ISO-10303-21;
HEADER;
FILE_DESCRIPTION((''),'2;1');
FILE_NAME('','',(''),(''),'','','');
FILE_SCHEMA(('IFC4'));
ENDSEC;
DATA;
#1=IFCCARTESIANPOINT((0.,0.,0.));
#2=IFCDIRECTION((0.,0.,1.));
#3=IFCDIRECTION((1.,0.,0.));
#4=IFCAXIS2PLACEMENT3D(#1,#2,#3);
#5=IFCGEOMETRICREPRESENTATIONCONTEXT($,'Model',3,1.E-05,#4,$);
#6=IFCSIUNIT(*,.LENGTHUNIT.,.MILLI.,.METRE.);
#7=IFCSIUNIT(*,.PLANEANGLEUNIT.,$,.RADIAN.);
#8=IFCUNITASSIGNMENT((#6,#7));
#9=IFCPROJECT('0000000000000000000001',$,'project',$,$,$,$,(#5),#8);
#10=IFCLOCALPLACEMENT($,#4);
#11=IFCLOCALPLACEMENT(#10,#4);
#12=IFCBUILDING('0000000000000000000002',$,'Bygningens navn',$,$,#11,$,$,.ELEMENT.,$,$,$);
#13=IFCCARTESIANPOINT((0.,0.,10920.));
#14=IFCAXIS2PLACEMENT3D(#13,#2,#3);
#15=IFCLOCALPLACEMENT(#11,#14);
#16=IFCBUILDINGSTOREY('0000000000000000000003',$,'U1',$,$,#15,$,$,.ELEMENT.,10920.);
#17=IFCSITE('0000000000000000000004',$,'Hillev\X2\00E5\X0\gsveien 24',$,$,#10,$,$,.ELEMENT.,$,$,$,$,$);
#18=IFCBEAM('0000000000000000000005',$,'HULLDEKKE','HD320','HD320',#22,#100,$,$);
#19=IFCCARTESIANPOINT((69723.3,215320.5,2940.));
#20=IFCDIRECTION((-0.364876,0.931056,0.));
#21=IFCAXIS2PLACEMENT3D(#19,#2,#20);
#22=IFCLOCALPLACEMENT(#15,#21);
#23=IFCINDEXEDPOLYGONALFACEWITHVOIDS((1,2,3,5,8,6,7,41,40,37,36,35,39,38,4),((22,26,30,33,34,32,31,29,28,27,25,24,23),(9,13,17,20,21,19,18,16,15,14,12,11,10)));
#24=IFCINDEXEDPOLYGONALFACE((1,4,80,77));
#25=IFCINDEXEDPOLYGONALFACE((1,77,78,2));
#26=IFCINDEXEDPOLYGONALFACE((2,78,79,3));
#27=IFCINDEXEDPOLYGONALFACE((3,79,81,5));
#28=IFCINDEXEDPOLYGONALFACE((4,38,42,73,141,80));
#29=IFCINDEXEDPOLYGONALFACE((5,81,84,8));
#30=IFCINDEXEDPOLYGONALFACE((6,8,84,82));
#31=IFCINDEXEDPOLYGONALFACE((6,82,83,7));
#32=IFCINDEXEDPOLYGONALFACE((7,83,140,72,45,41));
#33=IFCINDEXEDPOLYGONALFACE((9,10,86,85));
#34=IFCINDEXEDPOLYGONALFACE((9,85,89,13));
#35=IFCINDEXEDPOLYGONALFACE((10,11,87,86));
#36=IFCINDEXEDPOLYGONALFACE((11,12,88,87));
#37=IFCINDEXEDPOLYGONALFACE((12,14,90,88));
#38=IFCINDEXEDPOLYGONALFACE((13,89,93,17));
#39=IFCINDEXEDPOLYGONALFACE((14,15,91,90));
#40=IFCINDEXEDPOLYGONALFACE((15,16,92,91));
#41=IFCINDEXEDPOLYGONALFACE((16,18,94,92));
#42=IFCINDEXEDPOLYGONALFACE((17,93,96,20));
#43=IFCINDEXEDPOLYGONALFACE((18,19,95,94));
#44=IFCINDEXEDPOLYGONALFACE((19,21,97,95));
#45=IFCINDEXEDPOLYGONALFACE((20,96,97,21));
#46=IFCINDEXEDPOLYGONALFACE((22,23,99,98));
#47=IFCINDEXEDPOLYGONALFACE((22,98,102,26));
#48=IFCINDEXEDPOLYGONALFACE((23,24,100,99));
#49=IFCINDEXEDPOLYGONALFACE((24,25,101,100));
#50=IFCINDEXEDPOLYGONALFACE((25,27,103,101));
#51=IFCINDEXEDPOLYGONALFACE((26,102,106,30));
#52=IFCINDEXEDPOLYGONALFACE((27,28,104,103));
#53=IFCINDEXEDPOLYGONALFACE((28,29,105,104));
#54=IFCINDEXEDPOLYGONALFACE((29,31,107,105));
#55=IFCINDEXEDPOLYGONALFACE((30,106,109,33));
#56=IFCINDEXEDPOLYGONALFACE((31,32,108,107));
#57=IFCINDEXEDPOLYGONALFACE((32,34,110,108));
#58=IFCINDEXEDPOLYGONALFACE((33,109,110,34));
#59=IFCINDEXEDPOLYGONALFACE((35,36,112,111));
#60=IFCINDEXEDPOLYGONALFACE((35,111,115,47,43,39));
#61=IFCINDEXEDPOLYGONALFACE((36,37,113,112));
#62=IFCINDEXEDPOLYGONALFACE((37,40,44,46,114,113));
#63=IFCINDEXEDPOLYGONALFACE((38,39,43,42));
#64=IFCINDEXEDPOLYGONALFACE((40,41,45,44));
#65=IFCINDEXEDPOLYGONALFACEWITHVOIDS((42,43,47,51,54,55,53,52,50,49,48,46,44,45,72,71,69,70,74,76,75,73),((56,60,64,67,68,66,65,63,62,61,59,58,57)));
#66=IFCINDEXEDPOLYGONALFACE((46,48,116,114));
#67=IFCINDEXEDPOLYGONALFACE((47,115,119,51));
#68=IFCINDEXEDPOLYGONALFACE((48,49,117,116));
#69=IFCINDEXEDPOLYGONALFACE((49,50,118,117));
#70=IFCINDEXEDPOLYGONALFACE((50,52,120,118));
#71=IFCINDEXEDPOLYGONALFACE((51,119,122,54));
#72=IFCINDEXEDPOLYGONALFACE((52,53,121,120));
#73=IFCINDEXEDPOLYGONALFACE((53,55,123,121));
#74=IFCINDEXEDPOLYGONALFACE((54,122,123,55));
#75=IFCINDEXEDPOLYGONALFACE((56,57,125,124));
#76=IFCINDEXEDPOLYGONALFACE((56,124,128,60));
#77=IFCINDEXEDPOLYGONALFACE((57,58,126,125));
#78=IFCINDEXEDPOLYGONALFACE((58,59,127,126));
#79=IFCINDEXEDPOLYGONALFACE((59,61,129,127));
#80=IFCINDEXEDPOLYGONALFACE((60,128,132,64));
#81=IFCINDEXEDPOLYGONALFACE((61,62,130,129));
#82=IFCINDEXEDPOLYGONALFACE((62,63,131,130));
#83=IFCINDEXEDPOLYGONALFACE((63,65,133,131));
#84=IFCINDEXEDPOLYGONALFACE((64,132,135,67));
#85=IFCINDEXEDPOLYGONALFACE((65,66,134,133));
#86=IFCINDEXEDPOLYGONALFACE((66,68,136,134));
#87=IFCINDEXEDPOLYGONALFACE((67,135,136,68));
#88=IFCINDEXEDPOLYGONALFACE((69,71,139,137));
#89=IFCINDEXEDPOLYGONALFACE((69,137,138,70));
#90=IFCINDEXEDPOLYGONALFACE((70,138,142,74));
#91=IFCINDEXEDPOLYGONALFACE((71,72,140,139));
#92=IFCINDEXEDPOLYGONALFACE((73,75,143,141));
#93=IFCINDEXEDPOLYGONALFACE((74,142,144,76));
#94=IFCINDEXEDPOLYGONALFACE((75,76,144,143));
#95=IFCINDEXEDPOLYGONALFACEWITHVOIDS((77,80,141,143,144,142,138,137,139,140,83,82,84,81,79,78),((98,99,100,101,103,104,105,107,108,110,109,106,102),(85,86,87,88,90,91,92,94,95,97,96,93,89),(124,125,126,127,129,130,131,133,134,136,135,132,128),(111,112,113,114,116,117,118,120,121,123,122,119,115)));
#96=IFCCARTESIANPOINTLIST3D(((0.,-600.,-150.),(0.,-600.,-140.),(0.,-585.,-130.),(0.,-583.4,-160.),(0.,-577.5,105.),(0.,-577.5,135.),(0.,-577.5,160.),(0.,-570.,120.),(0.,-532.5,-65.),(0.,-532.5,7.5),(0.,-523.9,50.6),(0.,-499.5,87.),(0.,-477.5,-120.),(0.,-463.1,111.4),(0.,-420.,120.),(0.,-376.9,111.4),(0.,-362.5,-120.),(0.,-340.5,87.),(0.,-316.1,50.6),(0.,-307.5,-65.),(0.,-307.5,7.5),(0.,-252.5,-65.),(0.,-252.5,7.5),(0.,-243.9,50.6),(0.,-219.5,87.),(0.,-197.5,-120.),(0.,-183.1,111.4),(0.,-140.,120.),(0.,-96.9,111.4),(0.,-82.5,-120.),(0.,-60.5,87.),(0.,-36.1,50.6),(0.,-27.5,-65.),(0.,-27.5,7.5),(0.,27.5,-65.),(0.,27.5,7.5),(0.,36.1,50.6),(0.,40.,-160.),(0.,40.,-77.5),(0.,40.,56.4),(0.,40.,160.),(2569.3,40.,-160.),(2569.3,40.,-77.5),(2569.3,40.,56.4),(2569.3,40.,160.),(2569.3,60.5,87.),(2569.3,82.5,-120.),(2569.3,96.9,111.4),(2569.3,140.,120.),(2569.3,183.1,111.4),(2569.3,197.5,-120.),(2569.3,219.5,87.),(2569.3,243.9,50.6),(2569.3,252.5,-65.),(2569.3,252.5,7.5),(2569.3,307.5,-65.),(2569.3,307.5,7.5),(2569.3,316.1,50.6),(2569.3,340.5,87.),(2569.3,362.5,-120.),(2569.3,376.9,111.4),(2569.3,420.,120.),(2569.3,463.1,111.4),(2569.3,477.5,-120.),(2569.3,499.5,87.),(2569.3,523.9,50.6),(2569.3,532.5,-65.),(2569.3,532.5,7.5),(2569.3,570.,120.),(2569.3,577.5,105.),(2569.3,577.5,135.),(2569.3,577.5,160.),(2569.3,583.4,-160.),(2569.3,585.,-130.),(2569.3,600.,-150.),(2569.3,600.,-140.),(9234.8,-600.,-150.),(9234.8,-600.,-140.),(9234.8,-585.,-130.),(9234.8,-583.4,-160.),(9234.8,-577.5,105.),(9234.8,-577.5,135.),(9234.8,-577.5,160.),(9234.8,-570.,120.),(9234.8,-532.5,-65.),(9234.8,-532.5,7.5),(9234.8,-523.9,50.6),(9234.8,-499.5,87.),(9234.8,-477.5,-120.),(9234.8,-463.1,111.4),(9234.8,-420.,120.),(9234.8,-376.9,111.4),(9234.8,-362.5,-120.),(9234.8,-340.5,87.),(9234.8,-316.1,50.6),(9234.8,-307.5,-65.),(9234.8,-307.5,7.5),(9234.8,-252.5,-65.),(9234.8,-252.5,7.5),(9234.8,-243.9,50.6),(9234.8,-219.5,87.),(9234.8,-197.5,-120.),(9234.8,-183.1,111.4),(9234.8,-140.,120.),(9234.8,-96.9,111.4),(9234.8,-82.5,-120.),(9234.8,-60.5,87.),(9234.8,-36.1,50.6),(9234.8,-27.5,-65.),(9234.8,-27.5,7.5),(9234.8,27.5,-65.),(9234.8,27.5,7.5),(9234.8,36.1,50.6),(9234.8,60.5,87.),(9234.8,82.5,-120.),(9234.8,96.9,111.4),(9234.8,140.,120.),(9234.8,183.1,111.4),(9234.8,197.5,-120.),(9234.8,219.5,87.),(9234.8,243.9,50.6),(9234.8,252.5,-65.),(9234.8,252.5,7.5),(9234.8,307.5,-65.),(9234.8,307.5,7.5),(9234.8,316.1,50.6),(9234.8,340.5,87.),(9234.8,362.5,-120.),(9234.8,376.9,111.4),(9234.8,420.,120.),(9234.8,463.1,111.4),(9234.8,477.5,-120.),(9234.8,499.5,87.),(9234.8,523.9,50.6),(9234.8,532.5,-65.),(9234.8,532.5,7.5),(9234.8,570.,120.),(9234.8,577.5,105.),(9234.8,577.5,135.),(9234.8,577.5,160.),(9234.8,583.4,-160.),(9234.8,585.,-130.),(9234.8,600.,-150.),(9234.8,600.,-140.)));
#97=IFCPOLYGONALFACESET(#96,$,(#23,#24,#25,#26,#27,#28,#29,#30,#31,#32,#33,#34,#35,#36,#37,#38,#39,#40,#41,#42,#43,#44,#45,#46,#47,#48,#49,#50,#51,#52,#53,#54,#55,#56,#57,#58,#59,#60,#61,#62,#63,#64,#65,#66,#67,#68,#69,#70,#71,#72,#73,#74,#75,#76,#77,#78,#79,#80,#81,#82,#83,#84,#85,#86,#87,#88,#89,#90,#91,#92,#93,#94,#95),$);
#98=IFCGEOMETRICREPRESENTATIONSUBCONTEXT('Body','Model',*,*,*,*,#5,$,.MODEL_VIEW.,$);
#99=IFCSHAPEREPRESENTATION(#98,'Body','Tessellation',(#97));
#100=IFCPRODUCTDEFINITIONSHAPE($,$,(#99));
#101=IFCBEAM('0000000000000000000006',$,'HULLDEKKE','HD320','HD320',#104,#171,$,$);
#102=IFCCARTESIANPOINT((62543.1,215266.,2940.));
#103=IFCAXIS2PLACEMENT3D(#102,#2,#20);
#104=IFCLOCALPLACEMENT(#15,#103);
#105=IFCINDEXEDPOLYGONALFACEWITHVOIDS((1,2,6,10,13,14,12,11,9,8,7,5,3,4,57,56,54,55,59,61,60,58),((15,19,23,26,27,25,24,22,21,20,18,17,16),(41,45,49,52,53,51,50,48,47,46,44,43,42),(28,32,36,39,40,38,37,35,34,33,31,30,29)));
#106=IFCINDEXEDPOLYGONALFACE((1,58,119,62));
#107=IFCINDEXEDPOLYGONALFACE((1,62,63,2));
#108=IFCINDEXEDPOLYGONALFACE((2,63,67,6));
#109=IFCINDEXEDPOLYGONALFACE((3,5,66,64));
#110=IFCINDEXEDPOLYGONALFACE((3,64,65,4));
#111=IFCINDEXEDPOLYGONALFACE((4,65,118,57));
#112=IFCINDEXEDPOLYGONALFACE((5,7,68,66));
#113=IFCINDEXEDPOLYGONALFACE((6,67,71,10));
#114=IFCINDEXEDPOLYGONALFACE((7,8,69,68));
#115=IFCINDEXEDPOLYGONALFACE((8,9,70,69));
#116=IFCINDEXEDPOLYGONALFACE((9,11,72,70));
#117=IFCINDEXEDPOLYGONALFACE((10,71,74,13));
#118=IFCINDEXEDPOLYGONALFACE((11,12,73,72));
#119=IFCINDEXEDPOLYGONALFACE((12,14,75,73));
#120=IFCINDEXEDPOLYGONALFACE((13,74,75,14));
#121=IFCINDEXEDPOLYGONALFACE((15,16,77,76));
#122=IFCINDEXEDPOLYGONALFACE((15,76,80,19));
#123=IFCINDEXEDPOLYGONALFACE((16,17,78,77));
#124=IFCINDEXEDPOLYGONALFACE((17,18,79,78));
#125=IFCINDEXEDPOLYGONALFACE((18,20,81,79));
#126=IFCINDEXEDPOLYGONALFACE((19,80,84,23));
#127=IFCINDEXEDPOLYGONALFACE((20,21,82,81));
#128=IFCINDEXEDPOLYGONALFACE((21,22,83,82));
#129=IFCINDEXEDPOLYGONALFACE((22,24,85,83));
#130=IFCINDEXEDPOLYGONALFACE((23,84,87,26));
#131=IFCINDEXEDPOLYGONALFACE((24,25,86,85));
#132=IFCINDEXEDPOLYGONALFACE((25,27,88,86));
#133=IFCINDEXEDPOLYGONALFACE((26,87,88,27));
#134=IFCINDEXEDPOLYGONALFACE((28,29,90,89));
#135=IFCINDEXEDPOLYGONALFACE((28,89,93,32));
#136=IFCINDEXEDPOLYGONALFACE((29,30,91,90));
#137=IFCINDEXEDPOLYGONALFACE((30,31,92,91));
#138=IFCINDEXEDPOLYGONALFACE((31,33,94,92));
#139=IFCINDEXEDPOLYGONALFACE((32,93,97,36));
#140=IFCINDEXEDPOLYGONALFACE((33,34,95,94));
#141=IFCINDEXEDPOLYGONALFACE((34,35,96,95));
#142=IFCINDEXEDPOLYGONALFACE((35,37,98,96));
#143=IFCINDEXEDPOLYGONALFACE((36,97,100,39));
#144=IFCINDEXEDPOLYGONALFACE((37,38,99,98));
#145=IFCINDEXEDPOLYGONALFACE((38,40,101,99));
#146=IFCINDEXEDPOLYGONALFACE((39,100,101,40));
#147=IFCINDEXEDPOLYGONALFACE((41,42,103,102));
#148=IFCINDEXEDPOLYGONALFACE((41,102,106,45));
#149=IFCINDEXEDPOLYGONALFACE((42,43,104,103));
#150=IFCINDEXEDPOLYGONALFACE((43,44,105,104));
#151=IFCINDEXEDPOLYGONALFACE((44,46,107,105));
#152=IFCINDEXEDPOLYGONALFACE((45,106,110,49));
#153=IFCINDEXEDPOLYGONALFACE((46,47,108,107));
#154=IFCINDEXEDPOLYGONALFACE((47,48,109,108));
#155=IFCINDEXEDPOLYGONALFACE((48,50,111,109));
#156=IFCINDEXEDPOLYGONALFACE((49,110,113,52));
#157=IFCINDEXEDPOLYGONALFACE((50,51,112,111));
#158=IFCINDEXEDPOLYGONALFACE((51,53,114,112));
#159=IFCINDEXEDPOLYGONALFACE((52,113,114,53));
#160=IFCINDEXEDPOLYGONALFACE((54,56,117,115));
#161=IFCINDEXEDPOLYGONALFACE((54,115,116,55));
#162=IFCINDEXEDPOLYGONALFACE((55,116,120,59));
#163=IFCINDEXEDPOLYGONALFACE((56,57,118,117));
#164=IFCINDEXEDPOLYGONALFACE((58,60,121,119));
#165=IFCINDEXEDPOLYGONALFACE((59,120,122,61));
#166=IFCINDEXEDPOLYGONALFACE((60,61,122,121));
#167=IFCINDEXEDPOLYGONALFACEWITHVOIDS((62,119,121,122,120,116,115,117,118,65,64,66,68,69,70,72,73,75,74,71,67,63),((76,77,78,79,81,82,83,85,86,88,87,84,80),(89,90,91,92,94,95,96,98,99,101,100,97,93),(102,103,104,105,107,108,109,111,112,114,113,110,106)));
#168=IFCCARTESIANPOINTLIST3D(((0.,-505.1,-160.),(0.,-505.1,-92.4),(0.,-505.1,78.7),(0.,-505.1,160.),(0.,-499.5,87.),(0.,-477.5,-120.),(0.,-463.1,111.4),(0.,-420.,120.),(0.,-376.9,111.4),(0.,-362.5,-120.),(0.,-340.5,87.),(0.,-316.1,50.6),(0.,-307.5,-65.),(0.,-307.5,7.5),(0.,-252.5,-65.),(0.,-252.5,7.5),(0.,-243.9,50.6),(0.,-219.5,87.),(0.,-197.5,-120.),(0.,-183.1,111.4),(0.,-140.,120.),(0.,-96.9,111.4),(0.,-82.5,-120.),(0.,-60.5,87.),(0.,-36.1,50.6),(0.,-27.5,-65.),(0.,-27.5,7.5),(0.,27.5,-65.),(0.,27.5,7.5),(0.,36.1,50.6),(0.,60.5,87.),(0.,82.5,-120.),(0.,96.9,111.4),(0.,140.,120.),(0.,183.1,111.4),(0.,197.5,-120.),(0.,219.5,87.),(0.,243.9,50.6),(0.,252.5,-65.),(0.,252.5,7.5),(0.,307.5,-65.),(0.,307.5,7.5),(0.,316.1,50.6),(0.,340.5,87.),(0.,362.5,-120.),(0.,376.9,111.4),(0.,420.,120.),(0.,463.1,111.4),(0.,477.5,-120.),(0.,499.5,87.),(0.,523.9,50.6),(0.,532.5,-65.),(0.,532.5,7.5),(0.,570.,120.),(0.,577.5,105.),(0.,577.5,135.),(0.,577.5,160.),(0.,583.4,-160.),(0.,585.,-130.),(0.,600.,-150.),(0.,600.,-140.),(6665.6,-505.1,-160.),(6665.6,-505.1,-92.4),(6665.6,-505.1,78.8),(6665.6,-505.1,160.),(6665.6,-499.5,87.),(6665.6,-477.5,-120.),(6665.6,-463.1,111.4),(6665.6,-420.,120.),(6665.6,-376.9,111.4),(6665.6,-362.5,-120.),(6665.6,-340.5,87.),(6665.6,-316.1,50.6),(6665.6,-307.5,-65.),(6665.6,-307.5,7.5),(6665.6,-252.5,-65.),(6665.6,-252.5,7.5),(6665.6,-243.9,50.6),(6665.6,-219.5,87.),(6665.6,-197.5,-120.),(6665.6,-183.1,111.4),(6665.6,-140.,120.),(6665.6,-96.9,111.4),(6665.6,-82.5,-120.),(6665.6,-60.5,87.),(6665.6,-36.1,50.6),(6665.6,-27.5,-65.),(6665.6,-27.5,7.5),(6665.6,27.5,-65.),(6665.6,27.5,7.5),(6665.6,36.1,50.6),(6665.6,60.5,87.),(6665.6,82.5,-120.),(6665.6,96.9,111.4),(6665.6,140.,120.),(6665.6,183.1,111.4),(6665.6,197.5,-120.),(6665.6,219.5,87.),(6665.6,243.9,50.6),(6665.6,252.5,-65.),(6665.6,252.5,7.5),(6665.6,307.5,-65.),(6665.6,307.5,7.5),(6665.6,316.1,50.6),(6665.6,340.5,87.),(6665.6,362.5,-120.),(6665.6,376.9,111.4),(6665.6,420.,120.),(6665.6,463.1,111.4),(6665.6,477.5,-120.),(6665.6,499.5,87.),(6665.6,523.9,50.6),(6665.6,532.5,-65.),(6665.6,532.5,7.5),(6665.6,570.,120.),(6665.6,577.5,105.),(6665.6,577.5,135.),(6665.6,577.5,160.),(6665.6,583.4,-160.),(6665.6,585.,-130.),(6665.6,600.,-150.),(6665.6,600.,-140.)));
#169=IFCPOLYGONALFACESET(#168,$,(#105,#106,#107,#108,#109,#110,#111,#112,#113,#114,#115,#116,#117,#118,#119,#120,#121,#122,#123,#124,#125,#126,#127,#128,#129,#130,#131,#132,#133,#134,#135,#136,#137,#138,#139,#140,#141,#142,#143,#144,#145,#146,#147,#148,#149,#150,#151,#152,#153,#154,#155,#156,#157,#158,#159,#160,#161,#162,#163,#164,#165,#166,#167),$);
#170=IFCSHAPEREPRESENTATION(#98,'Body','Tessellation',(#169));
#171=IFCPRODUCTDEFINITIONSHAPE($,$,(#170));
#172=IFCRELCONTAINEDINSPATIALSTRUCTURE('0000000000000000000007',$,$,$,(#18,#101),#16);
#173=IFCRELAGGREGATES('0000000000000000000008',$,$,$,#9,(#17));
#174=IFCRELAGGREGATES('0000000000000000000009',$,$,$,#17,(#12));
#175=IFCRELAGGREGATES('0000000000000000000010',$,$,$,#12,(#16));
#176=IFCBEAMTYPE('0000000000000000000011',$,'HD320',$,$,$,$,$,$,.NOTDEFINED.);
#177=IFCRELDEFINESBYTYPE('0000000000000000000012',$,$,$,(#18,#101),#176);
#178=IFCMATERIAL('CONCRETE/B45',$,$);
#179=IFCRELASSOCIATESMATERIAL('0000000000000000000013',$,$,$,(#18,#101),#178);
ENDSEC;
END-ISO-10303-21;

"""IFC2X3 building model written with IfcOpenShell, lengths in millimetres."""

from ifc_helpers import new_model, si_unit, frame, origin_with_axes, place, context, subcontext, project, spatial, polyline, outline, extrude, boolean, clip, halfspace, material, type_object, element, save


model = new_model("IFC2X3")

# Units and contexts
model_context = context("Model", 3, precision=1e-05, world=origin_with_axes())
body_context = subcontext(model_context, "Body", "Model", "MODEL_VIEW")
ifc_project = project(units=[si_unit("LENGTHUNIT", "METRE", prefix="MILLI"), si_unit("PLANEANGLEUNIT", "RADIAN")], contexts=[model_context])

# Site, building, storey
site_placement = place(None, origin_with_axes())
site = spatial("IfcSite", under=ifc_project, at=site_placement, Name="Hillevågsveien 24", CompositionType="ELEMENT")
building_placement = place(site_placement, origin_with_axes())
building = spatial("IfcBuilding", under=site, at=building_placement, Name="Bygningens navn", CompositionType="ELEMENT")
storey_placement = place(building_placement, frame((0.0, 0.0, 10920.0), z_axis=(0.0, 0.0, 1.0), x_axis=(1.0, 0.0, 0.0)))
storey = spatial("IfcBuildingStorey", under=building, at=storey_placement, Name="U1", CompositionType="ELEMENT", Elevation=10920.0)

# Beams
ifc_material_1 = material(Name="CONCRETE/B45")
beam_type_1 = type_object("IfcBeamType", Name="HD320", PredefinedType="NOTDEFINED")
beam_1_placement = place(storey_placement, frame((69723.3, 215320.5, 2940.0), z_axis=(0.0, 0.0, 1.0), x_axis=(-0.364876, 0.931056, 0.0)))
element("IfcBeam", 1, at=beam_1_placement, inside=storey, type_object=beam_type_1, material=ifc_material_1, Name="HULLDEKKE", Description="HD320", ObjectType="HD320", context=body_context, shape_type="CSG", body=[
    boolean("DIFFERENCE", extrude(outline(polyline([(577.5, 105.0), (585.0, -130.0), (600.0, -140.0), (600.0, -150.0), (583.4, -160.0), (-583.4, -160.0), (-600.0, -150.0), (-600.0, -140.0), (-585.0, -130.0), (-577.5, 105.0), (-570.0, 120.0), (-577.5, 135.0), (-577.5, 160.0), (577.5, 160.0), (577.5, 135.0), (570.0, 120.0), (577.5, 105.0)]), holes=[polyline([(477.5, -120.0), (532.5, -65.0), (532.5, 7.5), (523.9, 50.6), (499.5, 87.0), (463.1, 111.4), (420.0, 120.0), (376.9, 111.4), (340.5, 87.0), (316.1, 50.6), (307.5, 7.5), (307.5, -65.0), (362.5, -120.0), (477.5, -120.0)]), polyline([(197.5, -120.0), (252.5, -65.0), (252.5, 7.5), (243.9, 50.6), (219.5, 87.0), (183.1, 111.4), (140.0, 120.0), (96.9, 111.4), (60.5, 87.0), (36.1, 50.6), (27.5, 7.5), (27.5, -65.0), (82.5, -120.0), (197.5, -120.0)]), polyline([(-82.5, -120.0), (-27.5, -65.0), (-27.5, 7.5), (-36.1, 50.6), (-60.5, 87.0), (-96.9, 111.4), (-140.0, 120.0), (-183.1, 111.4), (-219.5, 87.0), (-243.9, 50.6), (-252.5, 7.5), (-252.5, -65.0), (-197.5, -120.0), (-82.5, -120.0)]), polyline([(-362.5, -120.0), (-307.5, -65.0), (-307.5, 7.5), (-316.1, 50.6), (-340.5, 87.0), (-376.9, 111.4), (-420.0, 120.0), (-463.1, 111.4), (-499.5, 87.0), (-523.9, 50.6), (-532.5, 7.5), (-532.5, -65.0), (-477.5, -120.0), (-362.5, -120.0)])]), frame((9234.8, 0.0, 0.0), z_axis=(-1.0, 0.0, 0.0), x_axis=(0.0, -1.0, 0.0)), (0.0, 0.0, 1.0), 9234.8), extrude(outline(polyline([(0.0, 0.0), (800.0, 0.0), (800.0, 2579.3), (0.0, 2579.3), (0.0, 0.0)])), frame((-10.0, 840.0, -162.5), z_axis=(0.0, 0.0, 1.0), x_axis=(0.0, -1.0, 0.0)), (0.0, 0.0, 1.0), 325.0)),
])
beam_2_placement = place(storey_placement, frame((62543.1, 215266.0, 2940.0), z_axis=(0.0, 0.0, 1.0), x_axis=(-0.364876, 0.931056, 0.0)))
element("IfcBeam", 2, at=beam_2_placement, inside=storey, type_object=beam_type_1, material=ifc_material_1, Name="HULLDEKKE", Description="HD320", ObjectType="HD320", context=body_context, shape_type="Clipping", body=[
    clip(extrude(outline(polyline([(577.5, 105.0), (585.0, -130.0), (600.0, -140.0), (600.0, -150.0), (583.4, -160.0), (-583.4, -160.0), (-600.0, -150.0), (-600.0, -140.0), (-585.0, -130.0), (-577.5, 105.0), (-570.0, 120.0), (-577.5, 135.0), (-577.5, 160.0), (577.5, 160.0), (577.5, 135.0), (570.0, 120.0), (577.5, 105.0)]), holes=[polyline([(477.5, -120.0), (532.5, -65.0), (532.5, 7.5), (523.9, 50.6), (499.5, 87.0), (463.1, 111.4), (420.0, 120.0), (376.9, 111.4), (340.5, 87.0), (316.1, 50.6), (307.5, 7.5), (307.5, -65.0), (362.5, -120.0), (477.5, -120.0)]), polyline([(197.5, -120.0), (252.5, -65.0), (252.5, 7.5), (243.9, 50.6), (219.5, 87.0), (183.1, 111.4), (140.0, 120.0), (96.9, 111.4), (60.5, 87.0), (36.1, 50.6), (27.5, 7.5), (27.5, -65.0), (82.5, -120.0), (197.5, -120.0)]), polyline([(-82.5, -120.0), (-27.5, -65.0), (-27.5, 7.5), (-36.1, 50.6), (-60.5, 87.0), (-96.9, 111.4), (-140.0, 120.0), (-183.1, 111.4), (-219.5, 87.0), (-243.9, 50.6), (-252.5, 7.5), (-252.5, -65.0), (-197.5, -120.0), (-82.5, -120.0)]), polyline([(-362.5, -120.0), (-307.5, -65.0), (-307.5, 7.5), (-316.1, 50.6), (-340.5, 87.0), (-376.9, 111.4), (-420.0, 120.0), (-463.1, 111.4), (-499.5, 87.0), (-523.9, 50.6), (-532.5, 7.5), (-532.5, -65.0), (-477.5, -120.0), (-362.5, -120.0)])]), frame((6665.6, 0.0, 0.0), z_axis=(-1.0, 0.0, 0.0), x_axis=(0.0, -1.0, 0.0)), (0.0, 0.0, 1.0), 6665.6), halfspace(frame((120.7, -505.1, -160.0), z_axis=(0.000002, -1.0, 0.0), x_axis=(0.0, 0.0, 1.0)), False)),
])

save(model, "model.ifc")
